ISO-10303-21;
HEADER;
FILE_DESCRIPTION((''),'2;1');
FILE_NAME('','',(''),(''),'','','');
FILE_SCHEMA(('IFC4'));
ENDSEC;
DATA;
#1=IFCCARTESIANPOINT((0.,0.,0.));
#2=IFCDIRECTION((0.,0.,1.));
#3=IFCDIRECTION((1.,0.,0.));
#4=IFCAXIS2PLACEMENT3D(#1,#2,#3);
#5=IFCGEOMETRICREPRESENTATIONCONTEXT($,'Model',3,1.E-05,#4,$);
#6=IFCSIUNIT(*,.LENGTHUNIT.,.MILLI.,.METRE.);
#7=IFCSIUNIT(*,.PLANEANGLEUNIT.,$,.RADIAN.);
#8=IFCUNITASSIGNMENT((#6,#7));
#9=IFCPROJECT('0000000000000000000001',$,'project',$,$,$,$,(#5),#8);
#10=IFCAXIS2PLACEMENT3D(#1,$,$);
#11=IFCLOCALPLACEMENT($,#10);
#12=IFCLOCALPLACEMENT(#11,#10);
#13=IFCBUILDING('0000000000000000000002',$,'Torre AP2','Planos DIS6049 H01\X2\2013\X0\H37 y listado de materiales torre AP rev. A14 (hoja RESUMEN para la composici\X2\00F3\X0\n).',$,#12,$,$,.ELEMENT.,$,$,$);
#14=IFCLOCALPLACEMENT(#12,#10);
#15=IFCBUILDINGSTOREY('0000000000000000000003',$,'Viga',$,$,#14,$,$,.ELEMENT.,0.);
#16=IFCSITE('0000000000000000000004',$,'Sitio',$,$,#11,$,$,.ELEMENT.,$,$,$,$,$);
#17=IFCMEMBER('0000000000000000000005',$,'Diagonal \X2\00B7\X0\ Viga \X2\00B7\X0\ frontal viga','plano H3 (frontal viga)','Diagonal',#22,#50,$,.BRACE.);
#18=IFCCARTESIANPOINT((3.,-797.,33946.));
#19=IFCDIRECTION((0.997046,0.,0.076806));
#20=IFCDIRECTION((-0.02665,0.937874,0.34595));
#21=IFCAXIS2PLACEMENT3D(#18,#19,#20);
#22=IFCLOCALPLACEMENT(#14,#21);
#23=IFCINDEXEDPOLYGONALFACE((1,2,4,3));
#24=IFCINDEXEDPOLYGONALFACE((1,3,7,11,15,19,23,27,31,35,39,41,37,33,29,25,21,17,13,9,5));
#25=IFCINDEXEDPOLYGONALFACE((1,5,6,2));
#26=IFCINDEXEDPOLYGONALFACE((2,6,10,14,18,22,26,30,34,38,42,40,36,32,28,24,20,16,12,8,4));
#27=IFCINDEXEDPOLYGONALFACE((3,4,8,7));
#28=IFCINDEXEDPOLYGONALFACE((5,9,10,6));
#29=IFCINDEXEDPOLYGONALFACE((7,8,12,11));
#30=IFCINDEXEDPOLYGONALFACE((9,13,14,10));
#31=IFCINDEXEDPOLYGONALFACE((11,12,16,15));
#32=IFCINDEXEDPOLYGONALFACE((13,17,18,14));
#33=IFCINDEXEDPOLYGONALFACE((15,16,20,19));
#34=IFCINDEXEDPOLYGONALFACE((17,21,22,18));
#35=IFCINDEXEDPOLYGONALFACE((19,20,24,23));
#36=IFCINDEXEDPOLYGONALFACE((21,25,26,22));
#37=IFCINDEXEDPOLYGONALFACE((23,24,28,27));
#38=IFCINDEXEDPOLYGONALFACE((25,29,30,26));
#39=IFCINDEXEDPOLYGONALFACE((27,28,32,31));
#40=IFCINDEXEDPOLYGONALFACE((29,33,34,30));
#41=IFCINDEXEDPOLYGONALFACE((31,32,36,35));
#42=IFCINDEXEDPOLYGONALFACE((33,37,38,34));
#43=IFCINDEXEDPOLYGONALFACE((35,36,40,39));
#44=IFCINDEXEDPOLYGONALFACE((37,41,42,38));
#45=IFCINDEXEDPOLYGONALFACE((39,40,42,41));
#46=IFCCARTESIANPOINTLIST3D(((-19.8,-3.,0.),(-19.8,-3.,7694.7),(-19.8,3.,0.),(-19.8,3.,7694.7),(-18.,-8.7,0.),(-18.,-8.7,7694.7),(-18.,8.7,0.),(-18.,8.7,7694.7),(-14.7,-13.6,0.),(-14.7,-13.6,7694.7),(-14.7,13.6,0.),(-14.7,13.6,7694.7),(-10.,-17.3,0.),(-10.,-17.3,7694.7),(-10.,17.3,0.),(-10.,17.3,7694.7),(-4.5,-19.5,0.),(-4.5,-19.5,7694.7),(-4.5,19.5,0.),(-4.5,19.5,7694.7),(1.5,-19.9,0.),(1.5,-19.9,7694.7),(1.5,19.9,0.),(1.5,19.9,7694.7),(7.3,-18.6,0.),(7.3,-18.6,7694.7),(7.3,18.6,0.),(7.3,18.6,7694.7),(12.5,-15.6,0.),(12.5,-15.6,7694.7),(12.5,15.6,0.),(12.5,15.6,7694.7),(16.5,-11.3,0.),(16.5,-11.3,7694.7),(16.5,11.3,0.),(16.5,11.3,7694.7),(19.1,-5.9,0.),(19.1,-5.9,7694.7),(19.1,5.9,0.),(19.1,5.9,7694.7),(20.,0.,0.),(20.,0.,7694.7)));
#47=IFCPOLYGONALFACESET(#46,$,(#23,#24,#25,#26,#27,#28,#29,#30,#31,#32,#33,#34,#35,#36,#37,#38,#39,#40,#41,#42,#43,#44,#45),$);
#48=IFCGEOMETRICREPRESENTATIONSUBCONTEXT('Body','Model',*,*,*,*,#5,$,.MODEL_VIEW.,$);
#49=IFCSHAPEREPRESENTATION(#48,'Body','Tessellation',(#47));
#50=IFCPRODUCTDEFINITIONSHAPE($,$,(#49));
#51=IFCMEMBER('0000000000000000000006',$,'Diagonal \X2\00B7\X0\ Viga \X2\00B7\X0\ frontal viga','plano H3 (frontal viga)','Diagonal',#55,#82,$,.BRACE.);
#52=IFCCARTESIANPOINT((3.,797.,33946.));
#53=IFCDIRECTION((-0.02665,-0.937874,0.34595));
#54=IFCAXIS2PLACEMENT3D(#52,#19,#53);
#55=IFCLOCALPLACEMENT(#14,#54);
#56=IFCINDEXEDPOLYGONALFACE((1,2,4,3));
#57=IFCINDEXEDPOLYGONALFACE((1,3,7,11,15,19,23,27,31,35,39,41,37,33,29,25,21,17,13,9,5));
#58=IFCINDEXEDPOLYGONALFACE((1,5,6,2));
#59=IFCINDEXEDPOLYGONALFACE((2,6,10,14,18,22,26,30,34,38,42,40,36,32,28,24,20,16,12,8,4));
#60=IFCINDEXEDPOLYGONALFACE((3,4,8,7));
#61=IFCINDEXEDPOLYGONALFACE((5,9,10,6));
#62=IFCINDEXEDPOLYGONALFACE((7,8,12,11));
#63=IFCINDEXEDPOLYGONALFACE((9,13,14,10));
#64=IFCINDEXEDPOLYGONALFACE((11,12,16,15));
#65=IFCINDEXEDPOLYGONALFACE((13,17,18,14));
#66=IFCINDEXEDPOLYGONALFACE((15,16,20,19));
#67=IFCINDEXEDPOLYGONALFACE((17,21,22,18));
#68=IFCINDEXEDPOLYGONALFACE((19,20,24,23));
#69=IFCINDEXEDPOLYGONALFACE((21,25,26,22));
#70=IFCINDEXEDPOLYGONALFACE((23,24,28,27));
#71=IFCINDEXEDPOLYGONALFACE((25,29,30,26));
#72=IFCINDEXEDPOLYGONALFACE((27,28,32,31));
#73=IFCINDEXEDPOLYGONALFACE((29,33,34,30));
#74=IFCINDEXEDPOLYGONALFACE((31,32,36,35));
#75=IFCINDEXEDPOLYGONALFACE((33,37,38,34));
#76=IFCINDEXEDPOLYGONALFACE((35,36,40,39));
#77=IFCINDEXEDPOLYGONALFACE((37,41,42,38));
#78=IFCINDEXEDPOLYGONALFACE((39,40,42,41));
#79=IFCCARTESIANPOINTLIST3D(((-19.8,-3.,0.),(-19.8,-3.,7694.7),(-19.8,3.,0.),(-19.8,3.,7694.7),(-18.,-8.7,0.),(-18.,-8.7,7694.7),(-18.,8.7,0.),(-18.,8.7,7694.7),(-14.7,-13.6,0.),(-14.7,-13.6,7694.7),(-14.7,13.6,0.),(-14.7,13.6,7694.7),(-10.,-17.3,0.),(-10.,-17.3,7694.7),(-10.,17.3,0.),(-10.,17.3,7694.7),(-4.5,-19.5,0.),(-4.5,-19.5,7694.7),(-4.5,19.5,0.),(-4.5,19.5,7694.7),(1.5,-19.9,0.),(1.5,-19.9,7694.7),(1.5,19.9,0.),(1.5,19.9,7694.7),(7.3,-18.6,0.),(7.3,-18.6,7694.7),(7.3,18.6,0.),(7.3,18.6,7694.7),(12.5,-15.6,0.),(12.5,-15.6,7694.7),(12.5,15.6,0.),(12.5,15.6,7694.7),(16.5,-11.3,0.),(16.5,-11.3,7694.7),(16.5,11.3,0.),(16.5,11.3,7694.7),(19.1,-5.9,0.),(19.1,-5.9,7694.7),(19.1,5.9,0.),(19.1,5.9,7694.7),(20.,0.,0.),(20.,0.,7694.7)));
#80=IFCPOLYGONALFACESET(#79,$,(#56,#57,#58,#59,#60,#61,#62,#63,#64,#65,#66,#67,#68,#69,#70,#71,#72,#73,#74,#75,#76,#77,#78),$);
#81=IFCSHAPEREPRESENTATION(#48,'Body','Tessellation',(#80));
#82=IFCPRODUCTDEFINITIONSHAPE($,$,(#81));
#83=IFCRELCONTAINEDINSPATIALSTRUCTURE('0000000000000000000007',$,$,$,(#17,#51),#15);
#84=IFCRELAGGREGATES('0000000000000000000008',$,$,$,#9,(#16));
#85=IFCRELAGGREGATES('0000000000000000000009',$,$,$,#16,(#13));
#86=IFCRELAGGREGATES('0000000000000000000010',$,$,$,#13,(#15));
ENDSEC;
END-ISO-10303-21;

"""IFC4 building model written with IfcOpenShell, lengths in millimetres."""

from ifc_helpers import new_model, si_unit, frame, origin, origin_with_axes, place, context, subcontext, project, spatial, circle, extrude, element, save


model = new_model("IFC4")

# Units and contexts
model_context = context("Model", 3, precision=1e-05, world=origin_with_axes())
body_context = subcontext(model_context, "Body", "Model", "MODEL_VIEW")
ifc_project = project(units=[si_unit("LENGTHUNIT", "METRE", prefix="MILLI"), si_unit("PLANEANGLEUNIT", "RADIAN")], contexts=[model_context])

# Site, building, storey
site_placement = place(None, origin())
site = spatial("IfcSite", under=ifc_project, at=site_placement, Name="Sitio", CompositionType="ELEMENT")
building_placement = place(site_placement, origin())
building = spatial("IfcBuilding", under=site, at=building_placement, Name="Torre AP2", Description="Planos DIS6049 H01–H37 y listado de materiales torre AP rev. A14 (hoja RESUMEN para la composición).", CompositionType="ELEMENT")
storey_placement = place(building_placement, origin())
storey = spatial("IfcBuildingStorey", under=building, at=storey_placement, Name="Viga", CompositionType="ELEMENT", Elevation=0.0)

# Members
for number, where, z_axis, x_axis, name in (
    (1, (3.0, -797.0, 33946.0), (0.997046, 0.0, 0.076806), (-0.02665, 0.937874, 0.34595), "Diagonal · Viga · frontal viga"),
    (2, (3.0, 797.0, 33946.0), (0.997046, 0.0, 0.076806), (-0.02665, -0.937874, 0.34595), "Diagonal · Viga · frontal viga"),
):
    element("IfcMember", number, at=place(storey_placement, frame(where, z_axis=z_axis, x_axis=x_axis)), inside=storey, Name=name, Description="plano H3 (frontal viga)", ObjectType="Diagonal", PredefinedType="BRACE", context=body_context, shape_type="SweptSolid", body=[
        extrude(circle(Radius=20.0), None, (0.0, 0.0, 1.0), 7694.7),
    ])

save(model, "model.ifc")
